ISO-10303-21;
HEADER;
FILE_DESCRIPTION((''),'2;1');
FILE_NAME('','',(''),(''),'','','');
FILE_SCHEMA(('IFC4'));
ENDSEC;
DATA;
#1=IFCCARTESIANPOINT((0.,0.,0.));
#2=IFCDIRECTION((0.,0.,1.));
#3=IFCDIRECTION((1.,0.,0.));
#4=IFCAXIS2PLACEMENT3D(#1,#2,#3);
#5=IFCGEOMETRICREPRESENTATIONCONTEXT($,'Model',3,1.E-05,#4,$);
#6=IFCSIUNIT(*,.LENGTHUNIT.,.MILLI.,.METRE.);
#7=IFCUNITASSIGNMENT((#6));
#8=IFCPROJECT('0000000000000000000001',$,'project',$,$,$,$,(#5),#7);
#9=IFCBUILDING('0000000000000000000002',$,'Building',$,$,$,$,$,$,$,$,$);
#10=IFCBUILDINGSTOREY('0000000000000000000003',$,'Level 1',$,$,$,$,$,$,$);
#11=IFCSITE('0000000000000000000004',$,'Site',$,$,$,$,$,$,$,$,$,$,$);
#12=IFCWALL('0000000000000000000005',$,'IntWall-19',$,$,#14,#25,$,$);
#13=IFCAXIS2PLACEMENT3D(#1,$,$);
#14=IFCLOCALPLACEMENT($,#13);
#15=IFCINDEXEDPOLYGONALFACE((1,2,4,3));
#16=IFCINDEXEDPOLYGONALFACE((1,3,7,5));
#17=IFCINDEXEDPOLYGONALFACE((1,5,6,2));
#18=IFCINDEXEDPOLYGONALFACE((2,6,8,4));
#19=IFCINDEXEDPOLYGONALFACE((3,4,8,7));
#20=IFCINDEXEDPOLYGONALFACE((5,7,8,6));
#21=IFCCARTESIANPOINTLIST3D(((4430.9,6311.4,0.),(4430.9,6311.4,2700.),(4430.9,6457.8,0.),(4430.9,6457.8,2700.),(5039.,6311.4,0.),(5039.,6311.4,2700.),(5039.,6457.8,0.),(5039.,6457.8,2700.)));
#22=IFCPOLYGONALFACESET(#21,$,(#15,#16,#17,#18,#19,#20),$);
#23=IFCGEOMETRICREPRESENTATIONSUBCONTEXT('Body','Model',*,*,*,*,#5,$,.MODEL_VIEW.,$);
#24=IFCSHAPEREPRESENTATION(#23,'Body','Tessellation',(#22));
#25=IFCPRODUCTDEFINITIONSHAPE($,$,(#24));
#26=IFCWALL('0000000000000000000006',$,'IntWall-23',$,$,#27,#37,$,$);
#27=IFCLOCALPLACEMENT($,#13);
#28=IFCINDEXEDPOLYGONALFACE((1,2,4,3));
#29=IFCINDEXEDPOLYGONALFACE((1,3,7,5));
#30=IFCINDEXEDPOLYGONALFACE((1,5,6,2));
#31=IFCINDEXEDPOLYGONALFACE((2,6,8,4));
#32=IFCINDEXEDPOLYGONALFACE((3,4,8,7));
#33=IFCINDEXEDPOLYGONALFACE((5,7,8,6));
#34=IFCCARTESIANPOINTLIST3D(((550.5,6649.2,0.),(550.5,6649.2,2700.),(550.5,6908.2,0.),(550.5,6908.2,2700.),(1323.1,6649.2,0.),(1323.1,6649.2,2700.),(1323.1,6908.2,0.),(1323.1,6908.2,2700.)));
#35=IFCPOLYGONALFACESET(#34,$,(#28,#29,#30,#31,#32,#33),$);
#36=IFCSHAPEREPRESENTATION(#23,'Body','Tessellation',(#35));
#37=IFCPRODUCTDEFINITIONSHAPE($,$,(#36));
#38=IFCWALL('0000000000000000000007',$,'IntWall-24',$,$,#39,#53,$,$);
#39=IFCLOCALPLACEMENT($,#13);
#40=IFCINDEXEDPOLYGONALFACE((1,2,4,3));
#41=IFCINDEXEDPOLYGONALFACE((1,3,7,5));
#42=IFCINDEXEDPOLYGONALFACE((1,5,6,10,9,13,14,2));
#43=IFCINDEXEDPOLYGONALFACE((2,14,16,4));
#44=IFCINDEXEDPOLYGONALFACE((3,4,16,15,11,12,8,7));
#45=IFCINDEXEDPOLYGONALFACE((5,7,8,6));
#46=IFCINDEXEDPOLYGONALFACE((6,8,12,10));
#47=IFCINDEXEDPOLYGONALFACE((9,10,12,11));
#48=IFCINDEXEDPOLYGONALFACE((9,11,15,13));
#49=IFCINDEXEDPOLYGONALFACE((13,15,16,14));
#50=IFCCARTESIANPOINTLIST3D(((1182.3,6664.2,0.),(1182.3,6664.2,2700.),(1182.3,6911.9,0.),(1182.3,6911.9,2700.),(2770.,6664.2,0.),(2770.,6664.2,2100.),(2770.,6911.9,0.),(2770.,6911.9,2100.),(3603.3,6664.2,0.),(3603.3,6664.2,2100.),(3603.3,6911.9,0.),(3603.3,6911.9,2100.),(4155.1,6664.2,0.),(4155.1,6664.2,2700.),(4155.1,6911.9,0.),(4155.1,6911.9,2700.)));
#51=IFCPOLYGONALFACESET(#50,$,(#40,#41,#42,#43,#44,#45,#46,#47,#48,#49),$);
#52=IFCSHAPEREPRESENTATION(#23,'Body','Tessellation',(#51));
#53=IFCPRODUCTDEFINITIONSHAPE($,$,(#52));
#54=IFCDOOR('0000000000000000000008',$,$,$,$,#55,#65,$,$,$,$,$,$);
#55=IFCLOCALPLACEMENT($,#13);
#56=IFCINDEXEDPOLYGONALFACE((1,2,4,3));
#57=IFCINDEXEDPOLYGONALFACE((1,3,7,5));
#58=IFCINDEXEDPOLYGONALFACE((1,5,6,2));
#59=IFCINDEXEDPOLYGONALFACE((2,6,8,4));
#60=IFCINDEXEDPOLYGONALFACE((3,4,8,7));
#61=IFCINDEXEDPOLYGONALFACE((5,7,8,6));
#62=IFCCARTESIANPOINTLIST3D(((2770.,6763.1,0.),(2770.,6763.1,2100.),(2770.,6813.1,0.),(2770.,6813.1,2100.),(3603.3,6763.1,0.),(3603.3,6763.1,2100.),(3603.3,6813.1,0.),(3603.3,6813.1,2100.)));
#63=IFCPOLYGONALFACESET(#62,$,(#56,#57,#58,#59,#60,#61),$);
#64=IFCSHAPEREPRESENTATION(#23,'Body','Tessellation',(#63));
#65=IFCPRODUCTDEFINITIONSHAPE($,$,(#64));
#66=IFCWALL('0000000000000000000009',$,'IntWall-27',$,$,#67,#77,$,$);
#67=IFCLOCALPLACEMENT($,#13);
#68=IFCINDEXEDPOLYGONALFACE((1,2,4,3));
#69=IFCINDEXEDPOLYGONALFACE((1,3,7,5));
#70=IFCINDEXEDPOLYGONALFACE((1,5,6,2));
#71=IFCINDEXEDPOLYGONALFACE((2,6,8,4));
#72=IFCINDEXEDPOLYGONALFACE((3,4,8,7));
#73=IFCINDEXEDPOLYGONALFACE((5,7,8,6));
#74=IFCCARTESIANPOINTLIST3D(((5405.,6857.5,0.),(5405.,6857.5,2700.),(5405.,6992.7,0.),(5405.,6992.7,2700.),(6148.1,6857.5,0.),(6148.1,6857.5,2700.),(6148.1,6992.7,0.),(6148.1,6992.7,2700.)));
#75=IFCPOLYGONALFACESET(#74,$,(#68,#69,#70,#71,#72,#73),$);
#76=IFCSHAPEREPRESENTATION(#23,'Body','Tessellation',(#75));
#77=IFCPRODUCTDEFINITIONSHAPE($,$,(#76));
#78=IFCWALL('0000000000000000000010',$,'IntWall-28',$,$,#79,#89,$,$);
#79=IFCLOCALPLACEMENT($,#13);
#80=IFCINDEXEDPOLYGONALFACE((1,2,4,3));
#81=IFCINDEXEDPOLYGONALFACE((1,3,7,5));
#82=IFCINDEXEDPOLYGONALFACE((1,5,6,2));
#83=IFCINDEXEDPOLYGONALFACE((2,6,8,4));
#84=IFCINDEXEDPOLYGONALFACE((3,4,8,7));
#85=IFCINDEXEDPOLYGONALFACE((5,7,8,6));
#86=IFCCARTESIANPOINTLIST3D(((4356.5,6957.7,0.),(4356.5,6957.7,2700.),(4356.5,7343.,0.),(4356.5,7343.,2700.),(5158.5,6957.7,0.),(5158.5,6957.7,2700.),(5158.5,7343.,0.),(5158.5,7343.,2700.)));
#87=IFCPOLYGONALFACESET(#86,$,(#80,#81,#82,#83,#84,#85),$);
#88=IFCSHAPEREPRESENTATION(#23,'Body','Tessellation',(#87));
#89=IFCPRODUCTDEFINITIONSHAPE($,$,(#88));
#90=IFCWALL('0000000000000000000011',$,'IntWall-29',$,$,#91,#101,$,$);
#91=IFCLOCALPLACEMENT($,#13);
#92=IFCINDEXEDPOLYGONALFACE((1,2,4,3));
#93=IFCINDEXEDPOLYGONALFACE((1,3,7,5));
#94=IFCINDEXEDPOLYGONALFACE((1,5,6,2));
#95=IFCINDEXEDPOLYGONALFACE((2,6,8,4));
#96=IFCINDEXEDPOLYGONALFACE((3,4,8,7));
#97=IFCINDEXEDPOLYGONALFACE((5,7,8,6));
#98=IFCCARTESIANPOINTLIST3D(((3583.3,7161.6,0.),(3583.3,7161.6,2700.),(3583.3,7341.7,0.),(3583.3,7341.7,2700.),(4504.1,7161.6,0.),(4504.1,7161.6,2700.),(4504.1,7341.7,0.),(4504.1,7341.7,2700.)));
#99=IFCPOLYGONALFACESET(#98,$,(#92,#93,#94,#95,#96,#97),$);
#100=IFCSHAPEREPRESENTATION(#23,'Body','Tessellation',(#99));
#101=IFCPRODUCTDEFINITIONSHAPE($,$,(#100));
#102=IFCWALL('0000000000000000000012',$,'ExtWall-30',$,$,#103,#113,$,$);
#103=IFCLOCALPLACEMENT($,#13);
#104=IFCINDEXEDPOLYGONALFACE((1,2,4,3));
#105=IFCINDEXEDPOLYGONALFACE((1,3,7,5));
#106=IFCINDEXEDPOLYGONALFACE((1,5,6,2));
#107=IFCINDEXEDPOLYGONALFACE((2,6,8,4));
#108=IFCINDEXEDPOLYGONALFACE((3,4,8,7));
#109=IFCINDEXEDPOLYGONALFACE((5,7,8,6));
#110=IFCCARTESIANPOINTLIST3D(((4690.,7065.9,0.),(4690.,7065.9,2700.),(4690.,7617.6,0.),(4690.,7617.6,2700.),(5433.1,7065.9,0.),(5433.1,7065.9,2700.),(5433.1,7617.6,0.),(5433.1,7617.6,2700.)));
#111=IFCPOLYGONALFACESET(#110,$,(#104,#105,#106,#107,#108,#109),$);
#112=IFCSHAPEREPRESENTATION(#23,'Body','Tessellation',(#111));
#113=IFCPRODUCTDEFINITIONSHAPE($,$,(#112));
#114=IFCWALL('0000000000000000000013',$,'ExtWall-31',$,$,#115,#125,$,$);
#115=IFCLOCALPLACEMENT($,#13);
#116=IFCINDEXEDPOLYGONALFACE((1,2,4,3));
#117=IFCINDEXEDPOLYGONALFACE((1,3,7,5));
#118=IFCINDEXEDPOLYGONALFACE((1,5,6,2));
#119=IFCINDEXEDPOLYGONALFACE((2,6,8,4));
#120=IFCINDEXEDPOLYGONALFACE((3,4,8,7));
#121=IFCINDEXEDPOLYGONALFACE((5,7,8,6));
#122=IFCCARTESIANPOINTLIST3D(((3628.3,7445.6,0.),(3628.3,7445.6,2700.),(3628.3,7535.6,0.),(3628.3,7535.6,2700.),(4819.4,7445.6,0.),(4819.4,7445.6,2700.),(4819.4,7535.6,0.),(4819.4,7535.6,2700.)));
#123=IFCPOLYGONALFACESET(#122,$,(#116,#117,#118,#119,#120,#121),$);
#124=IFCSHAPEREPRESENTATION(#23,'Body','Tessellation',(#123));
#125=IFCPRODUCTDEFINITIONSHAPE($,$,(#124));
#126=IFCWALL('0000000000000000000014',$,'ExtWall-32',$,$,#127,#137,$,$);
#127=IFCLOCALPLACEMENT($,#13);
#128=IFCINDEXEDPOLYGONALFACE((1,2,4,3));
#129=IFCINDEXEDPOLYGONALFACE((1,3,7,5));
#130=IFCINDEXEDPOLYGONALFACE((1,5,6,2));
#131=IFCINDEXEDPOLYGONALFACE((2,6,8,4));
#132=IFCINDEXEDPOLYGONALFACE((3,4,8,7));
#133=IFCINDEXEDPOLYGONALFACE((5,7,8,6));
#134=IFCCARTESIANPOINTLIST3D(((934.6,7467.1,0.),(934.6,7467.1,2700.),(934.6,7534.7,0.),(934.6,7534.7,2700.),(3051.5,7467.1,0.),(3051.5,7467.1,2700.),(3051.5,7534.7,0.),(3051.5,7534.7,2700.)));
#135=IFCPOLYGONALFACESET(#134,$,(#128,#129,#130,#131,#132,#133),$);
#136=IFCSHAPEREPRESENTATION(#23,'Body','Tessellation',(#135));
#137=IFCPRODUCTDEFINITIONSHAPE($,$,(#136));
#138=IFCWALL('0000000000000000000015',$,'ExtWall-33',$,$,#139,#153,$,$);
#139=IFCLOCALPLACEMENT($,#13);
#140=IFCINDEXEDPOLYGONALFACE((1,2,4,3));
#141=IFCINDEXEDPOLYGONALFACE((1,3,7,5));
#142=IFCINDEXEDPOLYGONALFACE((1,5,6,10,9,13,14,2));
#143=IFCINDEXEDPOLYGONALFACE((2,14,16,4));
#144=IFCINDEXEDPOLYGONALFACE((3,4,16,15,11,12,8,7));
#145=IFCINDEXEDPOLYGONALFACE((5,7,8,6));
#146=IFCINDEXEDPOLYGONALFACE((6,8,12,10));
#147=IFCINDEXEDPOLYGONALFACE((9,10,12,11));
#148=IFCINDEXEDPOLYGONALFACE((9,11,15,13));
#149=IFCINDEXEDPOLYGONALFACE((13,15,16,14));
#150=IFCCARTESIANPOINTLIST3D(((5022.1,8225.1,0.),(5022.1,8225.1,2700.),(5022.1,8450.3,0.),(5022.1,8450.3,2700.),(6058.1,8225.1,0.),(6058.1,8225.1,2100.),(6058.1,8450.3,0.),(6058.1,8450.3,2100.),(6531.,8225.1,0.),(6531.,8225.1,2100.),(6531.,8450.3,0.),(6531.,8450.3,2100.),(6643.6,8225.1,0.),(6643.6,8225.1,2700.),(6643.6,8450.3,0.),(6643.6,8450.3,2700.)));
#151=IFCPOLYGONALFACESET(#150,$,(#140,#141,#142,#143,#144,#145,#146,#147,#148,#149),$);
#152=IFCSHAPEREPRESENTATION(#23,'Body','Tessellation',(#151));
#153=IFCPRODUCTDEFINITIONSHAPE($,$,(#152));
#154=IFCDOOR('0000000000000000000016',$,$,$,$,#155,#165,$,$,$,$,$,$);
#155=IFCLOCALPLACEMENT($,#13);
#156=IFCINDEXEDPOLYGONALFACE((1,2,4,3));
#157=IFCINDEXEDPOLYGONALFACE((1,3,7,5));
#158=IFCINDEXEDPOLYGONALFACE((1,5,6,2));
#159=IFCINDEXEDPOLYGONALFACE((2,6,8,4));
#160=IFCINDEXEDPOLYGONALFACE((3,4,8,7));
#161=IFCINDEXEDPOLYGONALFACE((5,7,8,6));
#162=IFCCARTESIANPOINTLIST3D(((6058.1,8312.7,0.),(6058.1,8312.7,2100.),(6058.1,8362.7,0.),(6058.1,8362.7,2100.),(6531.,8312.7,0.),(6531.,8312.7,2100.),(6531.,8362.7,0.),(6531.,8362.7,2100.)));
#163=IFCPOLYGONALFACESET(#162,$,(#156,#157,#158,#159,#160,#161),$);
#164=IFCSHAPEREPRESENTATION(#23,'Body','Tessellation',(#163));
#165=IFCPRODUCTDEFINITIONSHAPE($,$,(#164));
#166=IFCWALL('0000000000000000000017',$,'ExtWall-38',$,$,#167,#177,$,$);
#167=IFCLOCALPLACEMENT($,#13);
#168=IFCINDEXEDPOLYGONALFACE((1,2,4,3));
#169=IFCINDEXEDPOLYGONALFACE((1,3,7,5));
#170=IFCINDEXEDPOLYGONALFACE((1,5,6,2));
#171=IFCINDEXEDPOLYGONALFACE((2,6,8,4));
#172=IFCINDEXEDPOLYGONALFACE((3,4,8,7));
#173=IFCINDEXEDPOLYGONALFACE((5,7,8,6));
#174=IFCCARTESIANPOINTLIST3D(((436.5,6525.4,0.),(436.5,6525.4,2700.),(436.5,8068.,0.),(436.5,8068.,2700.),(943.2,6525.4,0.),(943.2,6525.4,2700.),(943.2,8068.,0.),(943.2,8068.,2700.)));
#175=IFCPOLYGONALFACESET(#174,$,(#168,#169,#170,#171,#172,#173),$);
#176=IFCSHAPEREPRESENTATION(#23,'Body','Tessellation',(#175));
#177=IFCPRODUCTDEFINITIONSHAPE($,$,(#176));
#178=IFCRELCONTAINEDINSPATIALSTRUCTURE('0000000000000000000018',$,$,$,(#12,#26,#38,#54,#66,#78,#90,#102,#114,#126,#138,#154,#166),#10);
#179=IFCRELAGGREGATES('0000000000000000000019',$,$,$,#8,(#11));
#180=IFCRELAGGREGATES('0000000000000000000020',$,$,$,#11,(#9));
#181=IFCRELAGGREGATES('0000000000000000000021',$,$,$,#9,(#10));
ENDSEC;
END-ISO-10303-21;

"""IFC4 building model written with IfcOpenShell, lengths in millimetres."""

from ifc_helpers import new_model, si_unit, frame, origin_with_axes, place, context, subcontext, project, spatial, indexed_curve, outline, extrude, element, fill, save


model = new_model("IFC4")

# Units and contexts
model_context = context("Model", 3, precision=1e-05, world=origin_with_axes())
body_context = subcontext(model_context, "Body", "Model", "MODEL_VIEW")
ifc_project = project(units=[si_unit("LENGTHUNIT", "METRE", prefix="MILLI")], contexts=[model_context])

# Site, building, storey
site = spatial("IfcSite", under=ifc_project, Name="Site")
building = spatial("IfcBuilding", under=site, Name="Building")
storey = spatial("IfcBuildingStorey", under=building, Name="Level 1")

# Walls
wall_1_placement = place(None, frame((4430.9, 6384.6, 0.0), z_axis=(0.0, 0.0, 1.0), x_axis=(1.0, 0.0, 0.0)))
element("IfcWall", 1, at=wall_1_placement, inside=storey, Name="IntWall-19", context=body_context, shape_type="SweptSolid", body=[
    extrude(outline(indexed_curve([(0.0, 0.0), (0.0, 146.4), (608.1, 146.4), (608.1, 0.0), (0.0, 0.0)], self_intersect=False)), frame((0.0, -73.2, 0.0), z_axis=(0.0, 0.0, 1.0), x_axis=(1.0, 0.0, 0.0)), (0.0, 0.0, 1.0), 2700.0),
])
wall_2_placement = place(None, frame((550.5, 6778.7, 0.0), z_axis=(0.0, 0.0, 1.0), x_axis=(1.0, 0.0, 0.0)))
element("IfcWall", 2, at=wall_2_placement, inside=storey, Name="IntWall-23", context=body_context, shape_type="SweptSolid", body=[
    extrude(outline(indexed_curve([(0.0, 0.0), (0.0, 259.0), (772.6, 259.0), (772.6, 0.0), (0.0, 0.0)], self_intersect=False)), frame((0.0, -129.5, 0.0), z_axis=(0.0, 0.0, 1.0), x_axis=(1.0, 0.0, 0.0)), (0.0, 0.0, 1.0), 2700.0),
])

# Wall, opening, door
wall_3_placement = place(None, frame((1182.3, 6788.1, 0.0), z_axis=(0.0, 0.0, 1.0), x_axis=(1.0, 0.0, 0.0)))
wall_3 = element("IfcWall", 3, at=wall_3_placement, inside=storey, Name="IntWall-24", context=body_context, shape_type="SweptSolid", body=[
    extrude(outline(indexed_curve([(0.0, 0.0), (0.0, 247.7), (2972.7, 247.7), (2972.7, 0.0), (0.0, 0.0)], self_intersect=False)), frame((0.0, -123.9, 0.0), z_axis=(0.0, 0.0, 1.0), x_axis=(1.0, 0.0, 0.0)), (0.0, 0.0, 1.0), 2700.0),
])
opening_1_placement = place(wall_3_placement, frame((1587.7, 0.0, 0.0), z_axis=(0.0, 0.0, 1.0), x_axis=(1.0, 0.0, 0.0)))
opening_1 = element("IfcOpeningElement", 4, at=opening_1_placement, cuts=wall_3, context=body_context, shape_type="SweptSolid", body=[
    extrude(outline(indexed_curve([(0.0, 0.0), (0.0, 347.7), (833.3, 347.7), (833.3, 0.0), (0.0, 0.0)], self_intersect=False)), frame((0.0, -173.9, 0.0), z_axis=(0.0, 0.0, 1.0), x_axis=(1.0, 0.0, 0.0)), (0.0, 0.0, 1.0), 2100.0),
])
door_1_placement = place(opening_1_placement, origin_with_axes())
door_1 = element("IfcDoor", 5, at=door_1_placement, inside=storey, context=body_context, shape_type="SweptSolid", body=[
    extrude(outline(indexed_curve([(0.0, 0.0), (0.0, 50.0), (833.3, 50.0), (833.3, 0.0), (0.0, 0.0)], self_intersect=False)), frame((0.0, -25.0, 0.0), z_axis=(0.0, 0.0, 1.0), x_axis=(1.0, 0.0, 0.0)), (0.0, 0.0, 1.0), 2100.0),
])
fill(opening_1, door_1)

# Walls
wall_4_placement = place(None, frame((5405.0, 6925.1, 0.0), z_axis=(0.0, 0.0, 1.0), x_axis=(1.0, 0.0, 0.0)))
element("IfcWall", 6, at=wall_4_placement, inside=storey, Name="IntWall-27", context=body_context, shape_type="SweptSolid", body=[
    extrude(outline(indexed_curve([(0.0, 0.0), (0.0, 135.1), (743.2, 135.1), (743.2, 0.0), (0.0, 0.0)], self_intersect=False)), frame((0.0, -67.6, 0.0), z_axis=(0.0, 0.0, 1.0), x_axis=(1.0, 0.0, 0.0)), (0.0, 0.0, 1.0), 2700.0),
])
wall_5_placement = place(None, frame((4356.5, 7150.3, 0.0), z_axis=(0.0, 0.0, 1.0), x_axis=(1.0, 0.0, 0.0)))
element("IfcWall", 7, at=wall_5_placement, inside=storey, Name="IntWall-28", context=body_context, shape_type="SweptSolid", body=[
    extrude(outline(indexed_curve([(0.0, 0.0), (0.0, 385.3), (801.9, 385.3), (801.9, 0.0), (0.0, 0.0)], self_intersect=False)), frame((0.0, -192.6, 0.0), z_axis=(0.0, 0.0, 1.0), x_axis=(1.0, 0.0, 0.0)), (0.0, 0.0, 1.0), 2700.0),
])
wall_6_placement = place(None, frame((3583.3, 7251.6, 0.0), z_axis=(0.0, 0.0, 1.0), x_axis=(1.0, 0.0, 0.0)))
element("IfcWall", 8, at=wall_6_placement, inside=storey, Name="IntWall-29", context=body_context, shape_type="SweptSolid", body=[
    extrude(outline(indexed_curve([(0.0, 0.0), (0.0, 180.2), (920.8, 180.2), (920.8, 0.0), (0.0, 0.0)], self_intersect=False)), frame((0.0, -90.1, 0.0), z_axis=(0.0, 0.0, 1.0), x_axis=(1.0, 0.0, 0.0)), (0.0, 0.0, 1.0), 2700.0),
])
wall_7_placement = place(None, frame((4690.0, 7341.7, 0.0), z_axis=(0.0, 0.0, 1.0), x_axis=(1.0, 0.0, 0.0)))
element("IfcWall", 9, at=wall_7_placement, inside=storey, Name="ExtWall-30", context=body_context, shape_type="SweptSolid", body=[
    extrude(outline(indexed_curve([(0.0, 0.0), (0.0, 551.7), (743.1, 551.7), (743.1, 0.0), (0.0, 0.0)], self_intersect=False)), frame((0.0, -275.8, 0.0), z_axis=(0.0, 0.0, 1.0), x_axis=(1.0, 0.0, 0.0)), (0.0, 0.0, 1.0), 2700.0),
])
wall_8_placement = place(None, frame((3628.3, 7490.6, 0.0), z_axis=(0.0, 0.0, 1.0), x_axis=(1.0, 0.0, 0.0)))
element("IfcWall", 10, at=wall_8_placement, inside=storey, Name="ExtWall-31", context=body_context, shape_type="SweptSolid", body=[
    extrude(outline(indexed_curve([(0.0, 0.0), (0.0, 90.1), (1191.1, 90.1), (1191.1, 0.0), (0.0, 0.0)], self_intersect=False)), frame((0.0, -45.0, 0.0), z_axis=(0.0, 0.0, 1.0), x_axis=(1.0, 0.0, 0.0)), (0.0, 0.0, 1.0), 2700.0),
])
wall_9_placement = place(None, frame((934.6, 7500.9, 0.0), z_axis=(0.0, 0.0, 1.0), x_axis=(1.0, 0.0, 0.0)))
element("IfcWall", 11, at=wall_9_placement, inside=storey, Name="ExtWall-32", context=body_context, shape_type="SweptSolid", body=[
    extrude(outline(indexed_curve([(0.0, 0.0), (0.0, 67.6), (2116.9, 67.6), (2116.9, 0.0), (0.0, 0.0)], self_intersect=False)), frame((0.0, -33.8, 0.0), z_axis=(0.0, 0.0, 1.0), x_axis=(1.0, 0.0, 0.0)), (0.0, 0.0, 1.0), 2700.0),
])

# Wall, opening, door
wall_10_placement = place(None, frame((5022.1, 8337.7, 0.0), z_axis=(0.0, 0.0, 1.0), x_axis=(1.0, 0.0, 0.0)))
wall_10 = element("IfcWall", 12, at=wall_10_placement, inside=storey, Name="ExtWall-33", context=body_context, shape_type="SweptSolid", body=[
    extrude(outline(indexed_curve([(0.0, 0.0), (0.0, 225.2), (1621.5, 225.2), (1621.5, 0.0), (0.0, 0.0)], self_intersect=False)), frame((0.0, -112.6, 0.0), z_axis=(0.0, 0.0, 1.0), x_axis=(1.0, 0.0, 0.0)), (0.0, 0.0, 1.0), 2700.0),
])
opening_2_placement = place(wall_10_placement, frame((1035.9, 0.0, 0.0), z_axis=(0.0, 0.0, 1.0), x_axis=(1.0, 0.0, 0.0)))
opening_2 = element("IfcOpeningElement", 13, at=opening_2_placement, cuts=wall_10, context=body_context, shape_type="SweptSolid", body=[
    extrude(outline(indexed_curve([(0.0, 0.0), (0.0, 325.2), (472.9, 325.2), (472.9, 0.0), (0.0, 0.0)], self_intersect=False)), frame((0.0, -162.6, 0.0), z_axis=(0.0, 0.0, 1.0), x_axis=(1.0, 0.0, 0.0)), (0.0, 0.0, 1.0), 2100.0),
])
door_2_placement = place(opening_2_placement, origin_with_axes())
door_2 = element("IfcDoor", 14, at=door_2_placement, inside=storey, context=body_context, shape_type="SweptSolid", body=[
    extrude(outline(indexed_curve([(0.0, 0.0), (0.0, 50.0), (472.9, 50.0), (472.9, 0.0), (0.0, 0.0)], self_intersect=False)), frame((0.0, -25.0, 0.0), z_axis=(0.0, 0.0, 1.0), x_axis=(1.0, 0.0, 0.0)), (0.0, 0.0, 1.0), 2100.0),
])
fill(opening_2, door_2)

# Wall
wall_11_placement = place(None, frame((689.8, 6525.4, 0.0), z_axis=(0.0, 0.0, 1.0), x_axis=(0.0, 1.0, 0.0)))
element("IfcWall", 15, at=wall_11_placement, inside=storey, Name="ExtWall-38", context=body_context, shape_type="SweptSolid", body=[
    extrude(outline(indexed_curve([(0.0, 0.0), (0.0, 506.7), (1542.7, 506.7), (1542.7, 0.0), (0.0, 0.0)], self_intersect=False)), frame((0.0, -253.4, 0.0), z_axis=(0.0, 0.0, 1.0), x_axis=(1.0, 0.0, 0.0)), (0.0, 0.0, 1.0), 2700.0),
])

save(model, "model.ifc")
